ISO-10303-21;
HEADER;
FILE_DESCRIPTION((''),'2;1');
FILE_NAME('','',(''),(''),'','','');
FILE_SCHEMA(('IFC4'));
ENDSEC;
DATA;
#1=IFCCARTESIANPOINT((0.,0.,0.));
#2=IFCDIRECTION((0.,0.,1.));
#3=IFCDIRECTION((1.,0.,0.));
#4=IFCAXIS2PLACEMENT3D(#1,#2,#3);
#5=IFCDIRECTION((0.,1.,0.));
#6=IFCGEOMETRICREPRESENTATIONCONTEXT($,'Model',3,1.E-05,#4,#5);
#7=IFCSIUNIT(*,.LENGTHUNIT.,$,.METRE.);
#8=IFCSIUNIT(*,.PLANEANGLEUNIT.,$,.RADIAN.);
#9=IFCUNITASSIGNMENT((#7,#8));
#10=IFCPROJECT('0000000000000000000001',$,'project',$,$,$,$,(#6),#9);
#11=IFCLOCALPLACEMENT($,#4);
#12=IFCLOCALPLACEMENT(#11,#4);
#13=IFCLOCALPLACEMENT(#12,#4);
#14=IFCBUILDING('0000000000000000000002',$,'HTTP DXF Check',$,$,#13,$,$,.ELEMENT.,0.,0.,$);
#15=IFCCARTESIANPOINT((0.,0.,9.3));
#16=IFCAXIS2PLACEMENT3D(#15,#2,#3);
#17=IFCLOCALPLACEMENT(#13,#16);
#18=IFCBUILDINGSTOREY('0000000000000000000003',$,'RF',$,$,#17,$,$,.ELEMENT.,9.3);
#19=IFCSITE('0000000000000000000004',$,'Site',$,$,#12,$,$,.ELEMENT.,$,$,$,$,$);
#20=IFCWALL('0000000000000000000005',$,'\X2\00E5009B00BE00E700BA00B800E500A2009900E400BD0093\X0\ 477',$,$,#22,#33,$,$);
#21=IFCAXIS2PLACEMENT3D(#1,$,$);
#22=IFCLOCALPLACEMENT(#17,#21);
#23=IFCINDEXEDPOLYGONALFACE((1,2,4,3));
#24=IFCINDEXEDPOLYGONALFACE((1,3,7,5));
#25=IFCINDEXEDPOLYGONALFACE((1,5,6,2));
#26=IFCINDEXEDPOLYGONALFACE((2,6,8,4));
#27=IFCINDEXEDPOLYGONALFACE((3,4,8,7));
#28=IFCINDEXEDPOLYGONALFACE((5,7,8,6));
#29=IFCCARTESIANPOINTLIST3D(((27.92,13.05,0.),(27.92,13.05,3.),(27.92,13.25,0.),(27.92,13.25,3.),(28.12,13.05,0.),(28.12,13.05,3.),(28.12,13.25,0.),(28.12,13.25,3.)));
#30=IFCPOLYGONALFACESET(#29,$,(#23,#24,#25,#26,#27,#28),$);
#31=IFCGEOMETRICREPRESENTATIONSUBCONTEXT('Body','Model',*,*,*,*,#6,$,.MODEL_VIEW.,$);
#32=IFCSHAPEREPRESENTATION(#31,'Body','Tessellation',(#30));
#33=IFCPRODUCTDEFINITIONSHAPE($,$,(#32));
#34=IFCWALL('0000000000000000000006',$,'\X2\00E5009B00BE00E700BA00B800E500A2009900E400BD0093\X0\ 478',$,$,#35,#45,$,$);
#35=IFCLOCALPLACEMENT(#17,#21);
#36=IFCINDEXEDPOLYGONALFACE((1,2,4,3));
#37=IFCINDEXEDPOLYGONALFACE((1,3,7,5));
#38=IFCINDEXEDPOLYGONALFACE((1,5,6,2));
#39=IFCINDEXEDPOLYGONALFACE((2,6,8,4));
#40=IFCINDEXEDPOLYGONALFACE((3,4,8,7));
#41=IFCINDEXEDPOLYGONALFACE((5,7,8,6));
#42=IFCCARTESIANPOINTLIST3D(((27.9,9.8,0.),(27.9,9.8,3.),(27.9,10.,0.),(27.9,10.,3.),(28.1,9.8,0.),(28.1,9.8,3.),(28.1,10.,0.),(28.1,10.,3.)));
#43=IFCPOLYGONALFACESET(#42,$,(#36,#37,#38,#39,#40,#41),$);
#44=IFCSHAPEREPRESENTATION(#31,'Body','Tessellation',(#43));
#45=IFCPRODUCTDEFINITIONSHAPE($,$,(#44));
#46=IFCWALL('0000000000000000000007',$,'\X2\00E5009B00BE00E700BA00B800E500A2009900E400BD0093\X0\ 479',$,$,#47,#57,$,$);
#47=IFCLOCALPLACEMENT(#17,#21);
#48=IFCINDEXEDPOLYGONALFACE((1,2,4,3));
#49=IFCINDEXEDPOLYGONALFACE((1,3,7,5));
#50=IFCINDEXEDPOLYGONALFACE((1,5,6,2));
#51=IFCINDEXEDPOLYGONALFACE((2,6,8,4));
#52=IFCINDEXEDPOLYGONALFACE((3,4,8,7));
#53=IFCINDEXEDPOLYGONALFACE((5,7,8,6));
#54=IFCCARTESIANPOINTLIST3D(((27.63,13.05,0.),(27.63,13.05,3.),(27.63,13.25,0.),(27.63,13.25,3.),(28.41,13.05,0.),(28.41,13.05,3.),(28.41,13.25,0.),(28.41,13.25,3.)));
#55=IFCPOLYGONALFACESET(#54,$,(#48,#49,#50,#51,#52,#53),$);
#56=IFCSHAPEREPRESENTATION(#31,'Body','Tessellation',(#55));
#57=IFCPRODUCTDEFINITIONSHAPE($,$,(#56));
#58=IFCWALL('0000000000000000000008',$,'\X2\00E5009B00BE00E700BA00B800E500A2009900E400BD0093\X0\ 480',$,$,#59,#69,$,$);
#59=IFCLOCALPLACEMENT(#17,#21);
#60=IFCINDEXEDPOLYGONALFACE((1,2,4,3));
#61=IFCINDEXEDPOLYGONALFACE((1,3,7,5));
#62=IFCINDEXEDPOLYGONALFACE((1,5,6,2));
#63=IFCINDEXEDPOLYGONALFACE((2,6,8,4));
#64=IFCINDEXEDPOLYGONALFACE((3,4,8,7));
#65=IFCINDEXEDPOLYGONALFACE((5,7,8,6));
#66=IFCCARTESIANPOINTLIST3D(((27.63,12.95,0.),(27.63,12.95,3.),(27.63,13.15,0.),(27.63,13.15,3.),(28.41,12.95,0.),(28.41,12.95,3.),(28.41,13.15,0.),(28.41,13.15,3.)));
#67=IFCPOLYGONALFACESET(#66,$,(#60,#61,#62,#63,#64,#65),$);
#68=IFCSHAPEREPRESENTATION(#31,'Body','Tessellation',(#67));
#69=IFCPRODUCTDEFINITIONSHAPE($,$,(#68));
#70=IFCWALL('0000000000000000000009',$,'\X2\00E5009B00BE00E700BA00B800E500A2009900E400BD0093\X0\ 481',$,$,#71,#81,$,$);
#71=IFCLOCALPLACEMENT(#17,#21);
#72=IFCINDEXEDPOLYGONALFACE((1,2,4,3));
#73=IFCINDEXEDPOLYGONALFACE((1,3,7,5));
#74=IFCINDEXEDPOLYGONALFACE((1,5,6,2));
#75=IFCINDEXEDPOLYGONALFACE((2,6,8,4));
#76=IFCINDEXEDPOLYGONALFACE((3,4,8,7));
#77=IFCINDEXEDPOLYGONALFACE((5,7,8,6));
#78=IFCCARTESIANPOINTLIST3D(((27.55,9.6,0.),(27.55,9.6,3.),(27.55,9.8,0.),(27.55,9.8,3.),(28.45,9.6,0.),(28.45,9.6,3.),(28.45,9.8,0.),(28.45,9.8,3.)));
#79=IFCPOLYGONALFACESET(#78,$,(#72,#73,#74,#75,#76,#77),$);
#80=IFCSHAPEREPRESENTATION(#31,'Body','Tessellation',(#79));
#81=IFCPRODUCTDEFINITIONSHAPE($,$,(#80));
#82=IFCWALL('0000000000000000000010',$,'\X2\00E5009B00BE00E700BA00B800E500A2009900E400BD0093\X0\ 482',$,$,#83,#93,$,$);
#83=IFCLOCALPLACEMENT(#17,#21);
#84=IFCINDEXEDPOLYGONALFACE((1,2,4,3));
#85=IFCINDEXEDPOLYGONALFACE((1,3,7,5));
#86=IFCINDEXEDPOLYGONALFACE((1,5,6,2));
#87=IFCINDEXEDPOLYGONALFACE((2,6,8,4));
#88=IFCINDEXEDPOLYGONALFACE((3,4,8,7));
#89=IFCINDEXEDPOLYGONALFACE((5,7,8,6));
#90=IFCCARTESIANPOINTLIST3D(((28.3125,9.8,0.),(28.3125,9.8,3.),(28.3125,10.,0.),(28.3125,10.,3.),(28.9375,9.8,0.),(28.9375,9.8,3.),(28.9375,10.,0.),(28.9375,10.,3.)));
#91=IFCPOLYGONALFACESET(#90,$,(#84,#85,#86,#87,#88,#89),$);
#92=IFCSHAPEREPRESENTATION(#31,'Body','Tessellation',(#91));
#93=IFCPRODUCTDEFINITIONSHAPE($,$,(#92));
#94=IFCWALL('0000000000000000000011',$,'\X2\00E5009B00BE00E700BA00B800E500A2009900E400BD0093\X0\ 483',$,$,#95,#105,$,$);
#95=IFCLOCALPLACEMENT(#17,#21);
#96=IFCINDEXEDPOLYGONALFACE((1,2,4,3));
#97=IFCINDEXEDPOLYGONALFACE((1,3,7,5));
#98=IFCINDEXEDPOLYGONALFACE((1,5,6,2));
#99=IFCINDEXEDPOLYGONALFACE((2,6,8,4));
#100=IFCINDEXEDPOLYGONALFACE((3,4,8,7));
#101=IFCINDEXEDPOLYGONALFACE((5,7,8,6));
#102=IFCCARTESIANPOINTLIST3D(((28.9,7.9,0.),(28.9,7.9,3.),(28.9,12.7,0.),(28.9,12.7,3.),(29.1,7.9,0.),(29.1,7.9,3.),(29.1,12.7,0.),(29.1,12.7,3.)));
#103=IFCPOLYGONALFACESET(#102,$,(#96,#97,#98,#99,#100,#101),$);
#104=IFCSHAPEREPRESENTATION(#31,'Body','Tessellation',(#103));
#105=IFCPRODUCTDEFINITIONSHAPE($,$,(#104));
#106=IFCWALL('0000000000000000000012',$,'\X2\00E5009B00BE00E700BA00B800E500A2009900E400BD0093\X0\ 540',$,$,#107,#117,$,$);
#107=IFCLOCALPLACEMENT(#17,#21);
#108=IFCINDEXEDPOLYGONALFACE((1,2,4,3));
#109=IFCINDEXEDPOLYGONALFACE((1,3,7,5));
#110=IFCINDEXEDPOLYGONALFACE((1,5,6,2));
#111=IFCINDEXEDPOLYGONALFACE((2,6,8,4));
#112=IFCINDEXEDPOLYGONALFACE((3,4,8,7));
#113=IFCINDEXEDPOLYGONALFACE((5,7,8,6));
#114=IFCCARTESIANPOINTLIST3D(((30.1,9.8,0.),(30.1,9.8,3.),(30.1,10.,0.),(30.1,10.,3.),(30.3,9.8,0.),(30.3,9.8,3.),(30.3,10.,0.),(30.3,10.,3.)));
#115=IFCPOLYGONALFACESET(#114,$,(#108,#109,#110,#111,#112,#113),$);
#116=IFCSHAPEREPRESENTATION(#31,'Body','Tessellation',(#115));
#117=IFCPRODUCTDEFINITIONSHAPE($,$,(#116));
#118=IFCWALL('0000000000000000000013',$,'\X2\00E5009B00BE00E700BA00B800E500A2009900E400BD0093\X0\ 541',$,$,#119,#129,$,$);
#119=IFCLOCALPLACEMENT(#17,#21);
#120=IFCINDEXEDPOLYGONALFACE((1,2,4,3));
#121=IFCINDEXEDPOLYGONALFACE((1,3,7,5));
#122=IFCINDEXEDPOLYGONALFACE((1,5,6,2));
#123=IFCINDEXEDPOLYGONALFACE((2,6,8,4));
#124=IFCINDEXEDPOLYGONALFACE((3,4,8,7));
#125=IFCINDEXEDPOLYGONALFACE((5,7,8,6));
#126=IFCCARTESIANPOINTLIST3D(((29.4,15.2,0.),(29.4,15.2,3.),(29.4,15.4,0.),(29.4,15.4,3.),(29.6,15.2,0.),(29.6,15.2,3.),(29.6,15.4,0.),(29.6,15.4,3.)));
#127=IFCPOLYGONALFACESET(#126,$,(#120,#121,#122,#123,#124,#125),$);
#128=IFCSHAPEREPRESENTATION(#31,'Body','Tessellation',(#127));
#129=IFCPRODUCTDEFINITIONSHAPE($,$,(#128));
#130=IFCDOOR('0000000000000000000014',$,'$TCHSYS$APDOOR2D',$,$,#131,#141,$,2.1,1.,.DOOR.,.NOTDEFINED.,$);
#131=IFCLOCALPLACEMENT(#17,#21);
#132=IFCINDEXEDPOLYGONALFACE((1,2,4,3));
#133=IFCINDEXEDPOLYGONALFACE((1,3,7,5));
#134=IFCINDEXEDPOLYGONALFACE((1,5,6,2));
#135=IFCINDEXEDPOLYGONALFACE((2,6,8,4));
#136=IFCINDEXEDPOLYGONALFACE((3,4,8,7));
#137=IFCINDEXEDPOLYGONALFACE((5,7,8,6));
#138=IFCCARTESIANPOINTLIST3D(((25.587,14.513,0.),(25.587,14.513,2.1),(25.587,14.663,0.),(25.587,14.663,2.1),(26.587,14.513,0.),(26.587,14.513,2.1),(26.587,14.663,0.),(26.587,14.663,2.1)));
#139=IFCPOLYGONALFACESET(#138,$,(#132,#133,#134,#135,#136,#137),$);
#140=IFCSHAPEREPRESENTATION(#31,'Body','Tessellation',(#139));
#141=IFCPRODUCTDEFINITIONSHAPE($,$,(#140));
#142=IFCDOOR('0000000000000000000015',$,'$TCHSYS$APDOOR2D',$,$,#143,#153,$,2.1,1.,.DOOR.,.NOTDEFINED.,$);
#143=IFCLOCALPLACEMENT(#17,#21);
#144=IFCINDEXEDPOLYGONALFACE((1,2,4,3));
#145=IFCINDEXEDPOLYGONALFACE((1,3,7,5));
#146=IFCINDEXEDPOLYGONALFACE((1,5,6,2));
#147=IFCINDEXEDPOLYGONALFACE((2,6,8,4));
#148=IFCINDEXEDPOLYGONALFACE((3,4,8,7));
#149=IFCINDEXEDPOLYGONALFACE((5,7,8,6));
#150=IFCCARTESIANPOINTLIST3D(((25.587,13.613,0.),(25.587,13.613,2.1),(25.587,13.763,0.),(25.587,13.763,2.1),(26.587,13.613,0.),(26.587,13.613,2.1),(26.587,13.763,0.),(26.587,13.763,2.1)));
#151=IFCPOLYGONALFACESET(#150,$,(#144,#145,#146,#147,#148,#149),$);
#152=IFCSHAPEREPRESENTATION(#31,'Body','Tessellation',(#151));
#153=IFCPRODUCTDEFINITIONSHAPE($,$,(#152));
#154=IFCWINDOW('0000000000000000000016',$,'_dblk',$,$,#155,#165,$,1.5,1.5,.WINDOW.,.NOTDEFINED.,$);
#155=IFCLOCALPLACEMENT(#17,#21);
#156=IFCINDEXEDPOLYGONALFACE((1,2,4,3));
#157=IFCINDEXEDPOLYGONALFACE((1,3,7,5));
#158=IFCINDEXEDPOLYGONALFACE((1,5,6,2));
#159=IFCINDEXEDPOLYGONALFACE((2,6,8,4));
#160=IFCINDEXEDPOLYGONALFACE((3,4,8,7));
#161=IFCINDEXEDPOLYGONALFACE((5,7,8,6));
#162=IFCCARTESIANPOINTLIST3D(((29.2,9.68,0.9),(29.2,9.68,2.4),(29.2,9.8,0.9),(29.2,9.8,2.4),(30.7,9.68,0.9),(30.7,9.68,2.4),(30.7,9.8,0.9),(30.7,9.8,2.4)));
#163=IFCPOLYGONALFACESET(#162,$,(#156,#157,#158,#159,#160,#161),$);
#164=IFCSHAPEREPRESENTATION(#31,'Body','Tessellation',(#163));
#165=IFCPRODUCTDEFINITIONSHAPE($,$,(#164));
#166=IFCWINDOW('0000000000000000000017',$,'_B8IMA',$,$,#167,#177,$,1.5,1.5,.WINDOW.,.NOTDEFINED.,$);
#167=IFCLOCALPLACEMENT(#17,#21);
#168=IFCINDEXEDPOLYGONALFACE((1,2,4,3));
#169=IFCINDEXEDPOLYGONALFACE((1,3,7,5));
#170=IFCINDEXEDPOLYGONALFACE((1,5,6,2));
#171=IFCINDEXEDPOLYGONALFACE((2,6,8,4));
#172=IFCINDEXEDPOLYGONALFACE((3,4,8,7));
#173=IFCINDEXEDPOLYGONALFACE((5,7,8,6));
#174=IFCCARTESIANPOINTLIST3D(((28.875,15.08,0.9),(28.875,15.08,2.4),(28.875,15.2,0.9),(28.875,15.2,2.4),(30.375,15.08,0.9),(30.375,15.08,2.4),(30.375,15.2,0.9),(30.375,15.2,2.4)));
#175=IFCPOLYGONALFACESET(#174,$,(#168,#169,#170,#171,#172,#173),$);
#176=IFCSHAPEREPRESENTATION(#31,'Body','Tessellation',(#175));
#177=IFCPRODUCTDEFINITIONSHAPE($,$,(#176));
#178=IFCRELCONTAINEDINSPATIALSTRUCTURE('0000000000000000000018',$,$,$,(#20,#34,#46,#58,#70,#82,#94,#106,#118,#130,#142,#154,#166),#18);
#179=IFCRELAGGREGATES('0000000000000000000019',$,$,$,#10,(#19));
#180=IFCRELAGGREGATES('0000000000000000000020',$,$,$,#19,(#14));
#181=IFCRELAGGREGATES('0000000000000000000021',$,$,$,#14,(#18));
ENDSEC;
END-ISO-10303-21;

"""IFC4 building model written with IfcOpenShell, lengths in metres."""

from ifc_helpers import new_model, si_unit, direction, frame, frame_2d, origin_with_axes, place, context, subcontext, project, spatial, rectangle, extrude, element, save


model = new_model("IFC4")

# Units and contexts
model_context = context("Model", 3, precision=1e-05, world=origin_with_axes(), true_north=direction((0.0, 1.0, 0.0)))
body_context = subcontext(model_context, "Body", "Model", "MODEL_VIEW")
ifc_project = project(units=[si_unit("LENGTHUNIT", "METRE"), si_unit("PLANEANGLEUNIT", "RADIAN")], contexts=[model_context])

# Site, building, storey
placement = place(None, origin_with_axes())
site_placement = place(placement, origin_with_axes())
site = spatial("IfcSite", under=ifc_project, at=site_placement, Name="Site", CompositionType="ELEMENT")
building_placement = place(site_placement, origin_with_axes())
building = spatial("IfcBuilding", under=site, at=building_placement, Name="HTTP DXF Check", CompositionType="ELEMENT", ElevationOfRefHeight=0.0, ElevationOfTerrain=0.0)
storey_placement = place(building_placement, frame((0.0, 0.0, 9.3), z_axis=(0.0, 0.0, 1.0), x_axis=(1.0, 0.0, 0.0)))
storey = spatial("IfcBuildingStorey", under=building, at=storey_placement, Name="RF", CompositionType="ELEMENT", Elevation=9.3)

# Walls
for number, where, z_axis, x_axis, name in (
    (1, (28.02, 13.15, 0.0), (0.0, 0.0, 1.0), (0.0, -1.0, 0.0), "å\u009b¾çº¸å¢\u0099ä½\u0093 477"),
    (2, (28.0, 9.9, 0.0), (0.0, 0.0, 1.0), (0.0, -1.0, 0.0), "å\u009b¾çº¸å¢\u0099ä½\u0093 478"),
):
    element("IfcWall", number, at=place(storey_placement, frame(where, z_axis=z_axis, x_axis=x_axis)), inside=storey, Name=name, context=body_context, shape_type="SweptSolid", body=[
        extrude(rectangle(XDim=0.2, YDim=0.2, at=frame_2d((0.0, 0.0), x_axis=(1.0, 0.0, 0.0))), frame((0.0, 0.0, 0.0), z_axis=(0.0, 0.0, 1.0)), (0.0, 0.0, 1.0), 3.0),
    ])
for number, where, z_axis, x_axis, name in (
    (3, (28.02, 13.15, 0.0), (0.0, 0.0, 1.0), (1.0, 0.0, 0.0), "å\u009b¾çº¸å¢\u0099ä½\u0093 479"),
    (4, (28.02, 13.05, 0.0), (0.0, 0.0, 1.0), (1.0, 0.0, 0.0), "å\u009b¾çº¸å¢\u0099ä½\u0093 480"),
):
    element("IfcWall", number, at=place(storey_placement, frame(where, z_axis=z_axis, x_axis=x_axis)), inside=storey, Name=name, context=body_context, shape_type="SweptSolid", body=[
        extrude(rectangle(XDim=0.78, YDim=0.2, at=frame_2d((0.0, 0.0), x_axis=(1.0, 0.0, 0.0))), frame((0.0, 0.0, 0.0), z_axis=(0.0, 0.0, 1.0)), (0.0, 0.0, 1.0), 3.0),
    ])
wall_1_placement = place(storey_placement, frame((28.0, 9.7, 0.0), z_axis=(0.0, 0.0, 1.0), x_axis=(1.0, 0.0, 0.0)))
element("IfcWall", 5, at=wall_1_placement, inside=storey, Name="å\u009b¾çº¸å¢\u0099ä½\u0093 481", context=body_context, shape_type="SweptSolid", body=[
    extrude(rectangle(XDim=0.9, YDim=0.2, at=frame_2d((0.0, 0.0), x_axis=(1.0, 0.0, 0.0))), frame((0.0, 0.0, 0.0), z_axis=(0.0, 0.0, 1.0)), (0.0, 0.0, 1.0), 3.0),
])
wall_2_placement = place(storey_placement, frame((28.625, 9.9, 0.0), z_axis=(0.0, 0.0, 1.0), x_axis=(-1.0, 0.0, 0.0)))
element("IfcWall", 6, at=wall_2_placement, inside=storey, Name="å\u009b¾çº¸å¢\u0099ä½\u0093 482", context=body_context, shape_type="SweptSolid", body=[
    extrude(rectangle(XDim=0.625, YDim=0.2, at=frame_2d((0.0, 0.0), x_axis=(1.0, 0.0, 0.0))), frame((0.0, 0.0, 0.0), z_axis=(0.0, 0.0, 1.0)), (0.0, 0.0, 1.0), 3.0),
])
wall_3_placement = place(storey_placement, frame((29.0, 10.3, 0.0), z_axis=(0.0, 0.0, 1.0), x_axis=(0.0, 1.0, 0.0)))
element("IfcWall", 7, at=wall_3_placement, inside=storey, Name="å\u009b¾çº¸å¢\u0099ä½\u0093 483", context=body_context, shape_type="SweptSolid", body=[
    extrude(rectangle(XDim=4.8, YDim=0.2, at=frame_2d((0.0, 0.0), x_axis=(1.0, 0.0, 0.0))), frame((0.0, 0.0, 0.0), z_axis=(0.0, 0.0, 1.0)), (0.0, 0.0, 1.0), 3.0),
])
for number, where, z_axis, x_axis, name in (
    (8, (30.2, 9.9, 0.0), (0.0, 0.0, 1.0), (0.0, -1.0, 0.0), "å\u009b¾çº¸å¢\u0099ä½\u0093 540"),
    (9, (29.5, 15.3, 0.0), (0.0, 0.0, 1.0), (0.0, -1.0, 0.0), "å\u009b¾çº¸å¢\u0099ä½\u0093 541"),
):
    element("IfcWall", number, at=place(storey_placement, frame(where, z_axis=z_axis, x_axis=x_axis)), inside=storey, Name=name, context=body_context, shape_type="SweptSolid", body=[
        extrude(rectangle(XDim=0.2, YDim=0.2, at=frame_2d((0.0, 0.0), x_axis=(1.0, 0.0, 0.0))), frame((0.0, 0.0, 0.0), z_axis=(0.0, 0.0, 1.0)), (0.0, 0.0, 1.0), 3.0),
    ])

# Doors
for number, where, z_axis, x_axis, name in (
    (10, (26.087, 14.588, 0.0), (0.0, 0.0, 1.0), (1.0, 0.0, 0.0), "$TCHSYS$APDOOR2D"),
    (11, (26.087, 13.688, 0.0), (0.0, 0.0, 1.0), (1.0, 0.0, 0.0), "$TCHSYS$APDOOR2D"),
):
    element("IfcDoor", number, at=place(storey_placement, frame(where, z_axis=z_axis, x_axis=x_axis)), inside=storey, Name=name, OperationType="NOTDEFINED", OverallHeight=2.1, OverallWidth=1.0, PredefinedType="DOOR", context=body_context, shape_type="SweptSolid", body=[
        extrude(rectangle(XDim=1.0, YDim=0.15, at=frame_2d((0.0, 0.0), x_axis=(1.0, 0.0, 0.0))), frame((0.0, 0.0, 0.0), z_axis=(0.0, 0.0, 1.0)), (0.0, 0.0, 1.0), 2.1),
    ])

# Windows
for number, where, z_axis, x_axis, name in (
    (12, (29.95, 9.74, 0.9), (0.0, 0.0, 1.0), (1.0, 0.0, 0.0), "_dblk"),
    (13, (29.625, 15.14, 0.9), (0.0, 0.0, 1.0), (1.0, 0.0, 0.0), "_B8IMA"),
):
    element("IfcWindow", number, at=place(storey_placement, frame(where, z_axis=z_axis, x_axis=x_axis)), inside=storey, Name=name, OverallHeight=1.5, OverallWidth=1.5, PartitioningType="NOTDEFINED", PredefinedType="WINDOW", context=body_context, shape_type="SweptSolid", body=[
        extrude(rectangle(XDim=1.5, YDim=0.12, at=frame_2d((0.0, 0.0), x_axis=(1.0, 0.0, 0.0))), frame((0.0, 0.0, 0.0), z_axis=(0.0, 0.0, 1.0)), (0.0, 0.0, 1.0), 1.5),
    ])

save(model, "model.ifc")
